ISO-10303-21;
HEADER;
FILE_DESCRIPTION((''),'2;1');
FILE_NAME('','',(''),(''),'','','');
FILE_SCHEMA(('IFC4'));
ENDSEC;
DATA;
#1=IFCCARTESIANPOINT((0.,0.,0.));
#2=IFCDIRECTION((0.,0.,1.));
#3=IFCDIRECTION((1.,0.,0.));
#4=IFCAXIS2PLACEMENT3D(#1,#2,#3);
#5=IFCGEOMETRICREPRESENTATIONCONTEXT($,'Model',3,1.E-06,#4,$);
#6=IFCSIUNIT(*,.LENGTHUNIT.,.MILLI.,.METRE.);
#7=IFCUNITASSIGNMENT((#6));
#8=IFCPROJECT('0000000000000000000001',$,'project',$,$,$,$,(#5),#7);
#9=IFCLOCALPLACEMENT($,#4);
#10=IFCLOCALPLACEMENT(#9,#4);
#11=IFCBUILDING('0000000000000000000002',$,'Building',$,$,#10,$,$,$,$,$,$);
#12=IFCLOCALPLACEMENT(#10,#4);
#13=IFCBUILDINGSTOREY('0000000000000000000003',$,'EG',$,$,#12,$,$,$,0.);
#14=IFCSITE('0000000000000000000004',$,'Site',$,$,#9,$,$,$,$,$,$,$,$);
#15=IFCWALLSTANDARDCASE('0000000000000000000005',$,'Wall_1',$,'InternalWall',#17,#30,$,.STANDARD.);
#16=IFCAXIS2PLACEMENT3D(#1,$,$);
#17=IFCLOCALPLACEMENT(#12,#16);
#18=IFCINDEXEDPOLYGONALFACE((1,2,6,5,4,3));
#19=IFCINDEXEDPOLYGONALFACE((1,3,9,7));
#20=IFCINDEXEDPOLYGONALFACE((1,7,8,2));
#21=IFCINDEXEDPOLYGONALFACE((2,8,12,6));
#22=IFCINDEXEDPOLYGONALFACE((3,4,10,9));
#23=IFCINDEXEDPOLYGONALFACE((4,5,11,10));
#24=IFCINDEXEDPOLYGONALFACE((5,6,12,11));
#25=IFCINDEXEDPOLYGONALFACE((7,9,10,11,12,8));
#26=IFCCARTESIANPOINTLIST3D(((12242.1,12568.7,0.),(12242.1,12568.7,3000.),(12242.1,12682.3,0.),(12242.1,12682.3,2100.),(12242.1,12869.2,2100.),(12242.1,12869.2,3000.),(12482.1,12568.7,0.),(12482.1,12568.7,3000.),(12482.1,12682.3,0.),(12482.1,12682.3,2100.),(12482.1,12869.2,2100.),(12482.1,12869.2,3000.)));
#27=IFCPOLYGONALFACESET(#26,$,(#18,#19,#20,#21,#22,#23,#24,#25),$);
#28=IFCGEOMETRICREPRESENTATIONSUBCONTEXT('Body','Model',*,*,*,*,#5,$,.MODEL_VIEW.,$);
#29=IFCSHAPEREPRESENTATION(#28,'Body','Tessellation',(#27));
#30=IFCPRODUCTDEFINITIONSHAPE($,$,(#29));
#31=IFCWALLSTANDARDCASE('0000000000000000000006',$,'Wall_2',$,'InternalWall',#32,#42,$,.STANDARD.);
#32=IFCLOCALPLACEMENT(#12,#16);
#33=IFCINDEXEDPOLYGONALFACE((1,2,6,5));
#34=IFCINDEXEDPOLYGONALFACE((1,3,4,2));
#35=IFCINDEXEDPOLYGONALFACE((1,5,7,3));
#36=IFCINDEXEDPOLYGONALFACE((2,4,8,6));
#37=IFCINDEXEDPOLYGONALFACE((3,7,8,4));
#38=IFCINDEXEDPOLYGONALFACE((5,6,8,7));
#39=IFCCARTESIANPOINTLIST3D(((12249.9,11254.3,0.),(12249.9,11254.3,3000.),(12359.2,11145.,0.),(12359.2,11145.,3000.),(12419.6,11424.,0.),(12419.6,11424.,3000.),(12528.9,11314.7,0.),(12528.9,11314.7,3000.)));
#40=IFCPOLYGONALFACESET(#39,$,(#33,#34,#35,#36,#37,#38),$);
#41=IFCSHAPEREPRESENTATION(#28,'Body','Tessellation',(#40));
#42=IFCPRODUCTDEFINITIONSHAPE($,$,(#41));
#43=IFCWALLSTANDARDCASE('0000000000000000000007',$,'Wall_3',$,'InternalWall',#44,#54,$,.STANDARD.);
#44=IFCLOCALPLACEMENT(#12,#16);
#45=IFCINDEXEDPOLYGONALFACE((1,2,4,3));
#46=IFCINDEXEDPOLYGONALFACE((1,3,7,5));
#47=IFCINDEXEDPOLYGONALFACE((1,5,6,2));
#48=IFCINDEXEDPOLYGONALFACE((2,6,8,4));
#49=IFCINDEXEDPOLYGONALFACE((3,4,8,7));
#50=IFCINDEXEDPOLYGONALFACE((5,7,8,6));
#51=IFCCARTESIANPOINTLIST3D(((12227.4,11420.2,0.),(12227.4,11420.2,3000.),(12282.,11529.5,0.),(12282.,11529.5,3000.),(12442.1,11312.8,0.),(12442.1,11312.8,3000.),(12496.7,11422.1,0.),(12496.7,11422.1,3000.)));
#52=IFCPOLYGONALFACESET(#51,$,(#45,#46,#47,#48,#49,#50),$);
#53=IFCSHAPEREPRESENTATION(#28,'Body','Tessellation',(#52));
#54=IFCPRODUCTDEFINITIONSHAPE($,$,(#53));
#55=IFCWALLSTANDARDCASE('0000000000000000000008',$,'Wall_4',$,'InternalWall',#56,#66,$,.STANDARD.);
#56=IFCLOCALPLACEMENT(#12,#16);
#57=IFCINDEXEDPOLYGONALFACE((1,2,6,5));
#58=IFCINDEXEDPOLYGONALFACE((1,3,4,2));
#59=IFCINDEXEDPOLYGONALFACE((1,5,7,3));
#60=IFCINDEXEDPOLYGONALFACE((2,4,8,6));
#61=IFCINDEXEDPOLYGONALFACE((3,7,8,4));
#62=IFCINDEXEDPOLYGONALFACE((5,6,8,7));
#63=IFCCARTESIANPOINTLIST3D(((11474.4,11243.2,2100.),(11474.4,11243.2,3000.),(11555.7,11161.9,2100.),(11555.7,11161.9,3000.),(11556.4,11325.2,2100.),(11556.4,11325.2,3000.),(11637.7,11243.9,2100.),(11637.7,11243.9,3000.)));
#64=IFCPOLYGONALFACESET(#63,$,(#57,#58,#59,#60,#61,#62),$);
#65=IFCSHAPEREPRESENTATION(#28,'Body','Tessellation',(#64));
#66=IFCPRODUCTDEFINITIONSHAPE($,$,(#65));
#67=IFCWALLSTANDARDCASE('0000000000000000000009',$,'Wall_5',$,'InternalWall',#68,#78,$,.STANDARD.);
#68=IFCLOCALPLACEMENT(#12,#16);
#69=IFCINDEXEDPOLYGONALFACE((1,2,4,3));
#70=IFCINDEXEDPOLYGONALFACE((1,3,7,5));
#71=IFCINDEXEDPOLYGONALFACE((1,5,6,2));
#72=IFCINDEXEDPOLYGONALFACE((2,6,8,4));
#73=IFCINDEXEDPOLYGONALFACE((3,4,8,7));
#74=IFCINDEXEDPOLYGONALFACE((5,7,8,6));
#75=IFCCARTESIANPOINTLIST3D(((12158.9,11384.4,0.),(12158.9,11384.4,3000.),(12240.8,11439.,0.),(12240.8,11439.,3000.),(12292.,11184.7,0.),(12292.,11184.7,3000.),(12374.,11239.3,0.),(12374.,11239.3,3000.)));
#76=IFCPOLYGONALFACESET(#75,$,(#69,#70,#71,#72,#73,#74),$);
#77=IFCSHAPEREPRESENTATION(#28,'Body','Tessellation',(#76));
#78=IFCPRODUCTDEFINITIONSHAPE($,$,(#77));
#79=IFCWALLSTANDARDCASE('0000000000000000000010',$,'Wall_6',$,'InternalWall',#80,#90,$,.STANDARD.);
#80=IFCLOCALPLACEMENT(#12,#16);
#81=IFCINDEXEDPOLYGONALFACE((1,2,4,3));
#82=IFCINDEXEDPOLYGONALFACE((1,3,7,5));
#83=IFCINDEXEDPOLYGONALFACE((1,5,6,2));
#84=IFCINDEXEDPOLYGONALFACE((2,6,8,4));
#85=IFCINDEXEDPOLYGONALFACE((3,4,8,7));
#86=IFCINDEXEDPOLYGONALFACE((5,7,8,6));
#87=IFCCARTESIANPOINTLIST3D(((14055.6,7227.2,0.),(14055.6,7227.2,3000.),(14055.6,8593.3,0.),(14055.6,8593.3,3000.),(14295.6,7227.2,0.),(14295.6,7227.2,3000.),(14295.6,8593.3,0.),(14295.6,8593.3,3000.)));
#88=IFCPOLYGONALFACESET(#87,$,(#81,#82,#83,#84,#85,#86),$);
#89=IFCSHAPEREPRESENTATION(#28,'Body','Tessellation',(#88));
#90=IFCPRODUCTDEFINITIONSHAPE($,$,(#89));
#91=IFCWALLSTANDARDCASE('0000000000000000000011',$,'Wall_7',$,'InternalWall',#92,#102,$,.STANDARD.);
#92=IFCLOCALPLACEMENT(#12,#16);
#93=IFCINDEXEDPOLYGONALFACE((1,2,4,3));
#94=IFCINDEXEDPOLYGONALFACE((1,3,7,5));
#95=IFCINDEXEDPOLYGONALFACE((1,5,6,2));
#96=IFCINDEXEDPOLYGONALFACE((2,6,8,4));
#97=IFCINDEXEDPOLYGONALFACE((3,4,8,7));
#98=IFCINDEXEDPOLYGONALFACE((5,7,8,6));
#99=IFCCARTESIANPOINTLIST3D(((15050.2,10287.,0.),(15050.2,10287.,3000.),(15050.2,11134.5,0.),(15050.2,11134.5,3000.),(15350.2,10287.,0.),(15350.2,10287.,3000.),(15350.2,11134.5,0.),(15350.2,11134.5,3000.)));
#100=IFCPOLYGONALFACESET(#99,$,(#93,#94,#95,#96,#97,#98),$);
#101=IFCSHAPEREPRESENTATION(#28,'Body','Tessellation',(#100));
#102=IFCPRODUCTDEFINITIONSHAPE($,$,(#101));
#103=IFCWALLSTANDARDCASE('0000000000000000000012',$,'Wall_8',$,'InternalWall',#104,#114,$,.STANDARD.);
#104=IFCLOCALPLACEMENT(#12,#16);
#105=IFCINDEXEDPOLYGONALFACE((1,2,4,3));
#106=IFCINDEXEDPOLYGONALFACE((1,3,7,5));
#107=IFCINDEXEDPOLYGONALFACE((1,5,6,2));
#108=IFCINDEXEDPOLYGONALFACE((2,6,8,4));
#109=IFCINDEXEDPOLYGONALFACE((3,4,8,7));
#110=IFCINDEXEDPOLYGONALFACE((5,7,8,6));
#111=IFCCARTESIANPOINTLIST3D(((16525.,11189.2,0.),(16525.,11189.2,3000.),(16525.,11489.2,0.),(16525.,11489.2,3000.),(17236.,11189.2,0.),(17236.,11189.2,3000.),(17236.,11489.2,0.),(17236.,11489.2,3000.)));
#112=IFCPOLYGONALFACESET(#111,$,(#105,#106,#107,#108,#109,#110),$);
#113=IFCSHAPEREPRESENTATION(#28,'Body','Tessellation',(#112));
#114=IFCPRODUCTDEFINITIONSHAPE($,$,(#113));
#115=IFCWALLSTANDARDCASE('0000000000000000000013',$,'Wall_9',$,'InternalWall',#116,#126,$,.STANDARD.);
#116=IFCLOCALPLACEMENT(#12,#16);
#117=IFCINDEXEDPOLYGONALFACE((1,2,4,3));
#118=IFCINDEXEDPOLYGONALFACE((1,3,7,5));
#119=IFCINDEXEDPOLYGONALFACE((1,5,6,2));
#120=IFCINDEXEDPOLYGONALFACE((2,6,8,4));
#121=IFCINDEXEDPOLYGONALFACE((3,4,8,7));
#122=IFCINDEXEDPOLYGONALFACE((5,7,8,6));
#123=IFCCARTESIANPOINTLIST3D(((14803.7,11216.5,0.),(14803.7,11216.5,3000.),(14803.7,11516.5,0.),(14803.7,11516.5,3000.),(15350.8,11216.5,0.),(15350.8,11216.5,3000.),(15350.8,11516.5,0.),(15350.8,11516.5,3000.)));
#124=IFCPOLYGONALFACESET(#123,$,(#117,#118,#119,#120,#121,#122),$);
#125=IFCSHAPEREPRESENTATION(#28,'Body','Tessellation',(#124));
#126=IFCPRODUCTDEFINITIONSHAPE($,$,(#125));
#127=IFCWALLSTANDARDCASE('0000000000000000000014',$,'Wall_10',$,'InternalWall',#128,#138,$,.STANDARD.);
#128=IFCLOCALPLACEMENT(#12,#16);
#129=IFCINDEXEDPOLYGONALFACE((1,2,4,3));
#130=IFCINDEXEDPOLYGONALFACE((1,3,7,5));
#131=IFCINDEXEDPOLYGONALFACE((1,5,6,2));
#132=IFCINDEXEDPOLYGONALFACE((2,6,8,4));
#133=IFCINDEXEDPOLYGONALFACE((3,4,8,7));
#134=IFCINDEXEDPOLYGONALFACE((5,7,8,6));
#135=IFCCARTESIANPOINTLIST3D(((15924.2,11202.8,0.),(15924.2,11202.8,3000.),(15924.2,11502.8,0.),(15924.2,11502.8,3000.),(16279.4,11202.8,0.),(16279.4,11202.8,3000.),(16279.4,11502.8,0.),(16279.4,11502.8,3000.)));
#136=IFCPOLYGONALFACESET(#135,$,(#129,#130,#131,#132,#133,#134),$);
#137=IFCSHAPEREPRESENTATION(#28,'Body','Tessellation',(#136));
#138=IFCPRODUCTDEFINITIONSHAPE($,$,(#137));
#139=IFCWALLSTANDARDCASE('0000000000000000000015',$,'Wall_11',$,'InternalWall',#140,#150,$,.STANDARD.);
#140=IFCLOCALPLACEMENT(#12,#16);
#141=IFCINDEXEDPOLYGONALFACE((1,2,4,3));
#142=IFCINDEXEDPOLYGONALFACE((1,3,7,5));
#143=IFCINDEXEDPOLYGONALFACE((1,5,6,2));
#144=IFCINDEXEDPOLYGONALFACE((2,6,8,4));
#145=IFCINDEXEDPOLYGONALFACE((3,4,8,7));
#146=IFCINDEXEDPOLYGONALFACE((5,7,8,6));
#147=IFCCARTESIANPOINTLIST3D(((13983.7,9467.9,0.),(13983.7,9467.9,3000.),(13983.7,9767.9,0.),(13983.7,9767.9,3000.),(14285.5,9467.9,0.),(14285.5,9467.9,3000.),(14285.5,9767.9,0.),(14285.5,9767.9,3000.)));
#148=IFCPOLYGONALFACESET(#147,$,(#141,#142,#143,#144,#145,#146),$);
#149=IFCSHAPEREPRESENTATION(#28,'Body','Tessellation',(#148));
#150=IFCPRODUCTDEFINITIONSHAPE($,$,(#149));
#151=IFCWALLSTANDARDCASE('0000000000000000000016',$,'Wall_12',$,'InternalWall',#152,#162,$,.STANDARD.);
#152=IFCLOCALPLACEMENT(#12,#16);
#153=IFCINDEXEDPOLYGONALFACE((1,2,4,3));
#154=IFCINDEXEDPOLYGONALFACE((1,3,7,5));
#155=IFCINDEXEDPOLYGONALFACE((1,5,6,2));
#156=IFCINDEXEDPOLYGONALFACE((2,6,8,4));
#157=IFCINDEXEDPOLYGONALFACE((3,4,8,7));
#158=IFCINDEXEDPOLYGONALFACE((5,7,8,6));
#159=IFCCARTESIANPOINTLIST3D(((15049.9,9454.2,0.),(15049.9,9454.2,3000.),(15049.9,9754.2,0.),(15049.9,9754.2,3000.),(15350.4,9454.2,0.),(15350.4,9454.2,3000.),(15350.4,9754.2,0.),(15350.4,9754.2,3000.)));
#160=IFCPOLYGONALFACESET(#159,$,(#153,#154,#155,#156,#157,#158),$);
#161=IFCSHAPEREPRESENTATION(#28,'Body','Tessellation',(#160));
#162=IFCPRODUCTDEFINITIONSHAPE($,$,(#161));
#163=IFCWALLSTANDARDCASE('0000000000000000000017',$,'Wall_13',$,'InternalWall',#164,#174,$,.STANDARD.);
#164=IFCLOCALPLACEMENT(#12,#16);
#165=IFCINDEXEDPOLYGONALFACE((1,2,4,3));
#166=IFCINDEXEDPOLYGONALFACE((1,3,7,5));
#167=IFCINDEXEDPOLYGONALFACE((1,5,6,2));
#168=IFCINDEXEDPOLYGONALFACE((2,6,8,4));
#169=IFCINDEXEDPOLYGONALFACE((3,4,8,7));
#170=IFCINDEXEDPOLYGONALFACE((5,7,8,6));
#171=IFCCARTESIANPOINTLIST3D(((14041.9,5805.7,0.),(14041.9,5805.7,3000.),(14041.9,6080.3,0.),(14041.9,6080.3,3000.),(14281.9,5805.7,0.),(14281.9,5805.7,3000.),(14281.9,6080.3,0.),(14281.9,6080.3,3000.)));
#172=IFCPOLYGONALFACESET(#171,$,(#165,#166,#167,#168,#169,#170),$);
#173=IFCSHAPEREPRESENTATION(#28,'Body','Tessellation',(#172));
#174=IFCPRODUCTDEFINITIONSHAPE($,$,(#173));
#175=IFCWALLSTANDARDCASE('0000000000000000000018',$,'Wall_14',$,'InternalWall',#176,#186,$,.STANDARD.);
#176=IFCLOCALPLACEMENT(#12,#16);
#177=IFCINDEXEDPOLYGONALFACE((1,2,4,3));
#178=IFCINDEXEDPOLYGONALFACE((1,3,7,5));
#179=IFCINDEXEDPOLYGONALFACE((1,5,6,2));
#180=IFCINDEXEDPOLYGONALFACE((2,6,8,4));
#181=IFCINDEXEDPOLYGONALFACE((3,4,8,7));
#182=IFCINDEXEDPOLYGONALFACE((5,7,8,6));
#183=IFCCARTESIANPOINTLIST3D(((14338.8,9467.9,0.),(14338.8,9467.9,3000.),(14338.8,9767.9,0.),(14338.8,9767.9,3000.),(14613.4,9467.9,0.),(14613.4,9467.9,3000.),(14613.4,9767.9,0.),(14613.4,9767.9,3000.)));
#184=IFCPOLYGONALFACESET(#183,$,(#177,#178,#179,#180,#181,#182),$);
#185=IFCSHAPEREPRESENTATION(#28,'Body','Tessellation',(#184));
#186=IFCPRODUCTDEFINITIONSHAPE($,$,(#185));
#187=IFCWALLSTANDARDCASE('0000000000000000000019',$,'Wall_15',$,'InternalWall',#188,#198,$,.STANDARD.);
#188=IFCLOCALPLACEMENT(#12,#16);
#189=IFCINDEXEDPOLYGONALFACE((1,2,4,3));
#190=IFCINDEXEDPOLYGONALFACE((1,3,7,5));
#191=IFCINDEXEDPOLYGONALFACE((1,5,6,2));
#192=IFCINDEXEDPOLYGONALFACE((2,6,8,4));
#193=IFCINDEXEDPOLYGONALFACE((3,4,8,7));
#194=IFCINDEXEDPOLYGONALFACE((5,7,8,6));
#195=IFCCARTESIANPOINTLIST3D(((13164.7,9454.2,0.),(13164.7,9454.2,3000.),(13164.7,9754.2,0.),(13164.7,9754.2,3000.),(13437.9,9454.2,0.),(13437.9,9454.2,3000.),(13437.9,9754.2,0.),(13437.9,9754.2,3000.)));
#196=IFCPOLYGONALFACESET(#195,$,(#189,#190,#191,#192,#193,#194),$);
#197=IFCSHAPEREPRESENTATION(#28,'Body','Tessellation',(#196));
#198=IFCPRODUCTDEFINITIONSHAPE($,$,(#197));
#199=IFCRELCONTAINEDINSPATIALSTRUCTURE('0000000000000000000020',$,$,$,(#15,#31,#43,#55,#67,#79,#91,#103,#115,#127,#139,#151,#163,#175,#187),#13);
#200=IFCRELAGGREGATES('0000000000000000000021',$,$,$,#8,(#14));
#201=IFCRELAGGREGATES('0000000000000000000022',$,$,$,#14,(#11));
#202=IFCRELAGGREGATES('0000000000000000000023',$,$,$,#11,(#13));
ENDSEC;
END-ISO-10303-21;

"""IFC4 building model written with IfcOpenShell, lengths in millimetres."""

from ifc_helpers import new_model, si_unit, frame, origin_with_axes, place, context, subcontext, project, spatial, rectangle, extrude, element, save


model = new_model("IFC4")

# Units and contexts
model_context = context("Model", 3, precision=1e-06, world=origin_with_axes())
body_context = subcontext(model_context, "Body", "Model", "MODEL_VIEW")
ifc_project = project(units=[si_unit("LENGTHUNIT", "METRE", prefix="MILLI")], contexts=[model_context])

# Site, building, storey
site_placement = place(None, origin_with_axes())
site = spatial("IfcSite", under=ifc_project, at=site_placement, Name="Site")
building_placement = place(site_placement, origin_with_axes())
building = spatial("IfcBuilding", under=site, at=building_placement, Name="Building")
storey_placement = place(building_placement, origin_with_axes())
storey = spatial("IfcBuildingStorey", under=building, at=storey_placement, Name="EG", Elevation=0.0)

# Wall, opening
wall_1_placement = place(storey_placement, origin_with_axes())
wall_1 = element("IfcWallStandardCase", 1, at=wall_1_placement, inside=storey, Name="Wall_1", ObjectType="InternalWall", PredefinedType="STANDARD", context=body_context, shape_type="SweptSolid", body=[
    extrude(rectangle(XDim=300.5, YDim=240.0), frame((12362.1, 12719.0, 0.0), z_axis=(0.0, 0.0, 1.0), x_axis=(0.0, -1.0, 0.0)), (0.0, 0.0, 1.0), 3000.0),
])
opening_1_placement = place(wall_1_placement, origin_with_axes())
element("IfcOpeningElement", 2, at=opening_1_placement, inside=storey, cuts=wall_1, context=body_context, shape_type="SweptSolid", body=[
    extrude(rectangle(XDim=937.5, YDim=240.0), frame((12362.1, 13151.0, 0.0), z_axis=(0.0, 0.0, 1.0), x_axis=(0.0, -1.0, 0.0)), (0.0, 0.0, 1.0), 2100.0),
])

# Walls
wall_2_placement = place(storey_placement, origin_with_axes())
element("IfcWallStandardCase", 3, at=wall_2_placement, inside=storey, Name="Wall_2", ObjectType="InternalWall", PredefinedType="STANDARD", context=body_context, shape_type="SweptSolid", body=[
    extrude(rectangle(XDim=154.6, YDim=240.0), frame((12389.4, 11284.5, 0.0), z_axis=(0.0, 0.0, 1.0), x_axis=(0.707107, -0.707107, 0.0)), (0.0, 0.0, 1.0), 3000.0),
])
wall_3_placement = place(storey_placement, origin_with_axes())
element("IfcWallStandardCase", 4, at=wall_3_placement, inside=storey, Name="Wall_3", ObjectType="InternalWall", PredefinedType="STANDARD", context=body_context, shape_type="SweptSolid", body=[
    extrude(rectangle(XDim=122.2, YDim=240.0), frame((12362.1, 11421.1, 0.0), z_axis=(0.0, 0.0, 1.0), x_axis=(-0.447214, -0.894427, 0.0)), (0.0, 0.0, 1.0), 3000.0),
])

# Wall, opening
wall_4_placement = place(storey_placement, origin_with_axes())
wall_4 = element("IfcWallStandardCase", 5, at=wall_4_placement, inside=storey, Name="Wall_4", ObjectType="InternalWall", PredefinedType="STANDARD", context=body_context, shape_type="SweptSolid", body=[
    extrude(rectangle(XDim=115.9, YDim=115.0), frame((11556.0, 11243.5, 0.0), z_axis=(0.0, 0.0, 1.0), x_axis=(-0.707107, -0.707107, 0.0)), (0.0, 0.0, 1.0), 3000.0),
])
opening_2_placement = place(wall_4_placement, origin_with_axes())
element("IfcOpeningElement", 6, at=opening_2_placement, inside=storey, cuts=wall_4, context=body_context, shape_type="SweptSolid", body=[
    extrude(rectangle(XDim=939.1, YDim=115.0), frame((11399.7, 11087.2, 0.0), z_axis=(0.0, 0.0, 1.0), x_axis=(-0.707107, -0.707107, 0.0)), (0.0, 0.0, 1.0), 2100.0),
])

# Walls
wall_5_placement = place(storey_placement, origin_with_axes())
element("IfcWallStandardCase", 7, at=wall_5_placement, inside=storey, Name="Wall_5", ObjectType="InternalWall", PredefinedType="STANDARD", context=body_context, shape_type="SweptSolid", body=[
    extrude(rectangle(XDim=98.5, YDim=240.0), frame((12266.4, 11311.9, 0.0), z_axis=(0.0, 0.0, 1.0), x_axis=(-0.83205, -0.5547, 0.0)), (0.0, 0.0, 1.0), 3000.0),
])
wall_6_placement = place(storey_placement, origin_with_axes())
element("IfcWallStandardCase", 8, at=wall_6_placement, inside=storey, Name="Wall_6", ObjectType="InternalWall", PredefinedType="STANDARD", context=body_context, shape_type="SweptSolid", body=[
    extrude(rectangle(XDim=1366.1, YDim=240.0), frame((14175.6, 7910.2, 0.0), z_axis=(0.0, 0.0, 1.0), x_axis=(0.0, -1.0, 0.0)), (0.0, 0.0, 1.0), 3000.0),
])
wall_7_placement = place(storey_placement, origin_with_axes())
element("IfcWallStandardCase", 9, at=wall_7_placement, inside=storey, Name="Wall_7", ObjectType="InternalWall", PredefinedType="STANDARD", context=body_context, shape_type="SweptSolid", body=[
    extrude(rectangle(XDim=847.4, YDim=300.0), frame((15200.2, 10710.8, 0.0), z_axis=(0.0, 0.0, 1.0), x_axis=(0.0, 1.0, 0.0)), (0.0, 0.0, 1.0), 3000.0),
])
wall_8_placement = place(storey_placement, origin_with_axes())
element("IfcWallStandardCase", 10, at=wall_8_placement, inside=storey, Name="Wall_8", ObjectType="InternalWall", PredefinedType="STANDARD", context=body_context, shape_type="SweptSolid", body=[
    extrude(rectangle(XDim=710.9, YDim=300.0), frame((16880.5, 11339.2, 0.0), z_axis=(0.0, 0.0, 1.0), x_axis=(1.0, 0.0, 0.0)), (0.0, 0.0, 1.0), 3000.0),
])
wall_9_placement = place(storey_placement, origin_with_axes())
element("IfcWallStandardCase", 11, at=wall_9_placement, inside=storey, Name="Wall_9", ObjectType="InternalWall", PredefinedType="STANDARD", context=body_context, shape_type="SweptSolid", body=[
    extrude(rectangle(XDim=547.1, YDim=300.0), frame((15077.2, 11366.5, 0.0), z_axis=(0.0, 0.0, 1.0), x_axis=(1.0, 0.0, 0.0)), (0.0, 0.0, 1.0), 3000.0),
])
wall_10_placement = place(storey_placement, origin_with_axes())
element("IfcWallStandardCase", 12, at=wall_10_placement, inside=storey, Name="Wall_10", ObjectType="InternalWall", PredefinedType="STANDARD", context=body_context, shape_type="SweptSolid", body=[
    extrude(rectangle(XDim=355.2, YDim=300.0), frame((16101.8, 11352.8, 0.0), z_axis=(0.0, 0.0, 1.0), x_axis=(-1.0, 0.0, 0.0)), (0.0, 0.0, 1.0), 3000.0),
])
wall_11_placement = place(storey_placement, origin_with_axes())
element("IfcWallStandardCase", 13, at=wall_11_placement, inside=storey, Name="Wall_11", ObjectType="InternalWall", PredefinedType="STANDARD", context=body_context, shape_type="SweptSolid", body=[
    extrude(rectangle(XDim=301.8, YDim=300.0), frame((14134.6, 9617.9, 0.0), z_axis=(0.0, 0.0, 1.0), x_axis=(1.0, 0.0, 0.0)), (0.0, 0.0, 1.0), 3000.0),
])
wall_12_placement = place(storey_placement, origin_with_axes())
element("IfcWallStandardCase", 14, at=wall_12_placement, inside=storey, Name="Wall_12", ObjectType="InternalWall", PredefinedType="STANDARD", context=body_context, shape_type="SweptSolid", body=[
    extrude(rectangle(XDim=300.5, YDim=300.0), frame((15200.2, 9604.2, 0.0), z_axis=(0.0, 0.0, 1.0), x_axis=(1.0, 0.0, 0.0)), (0.0, 0.0, 1.0), 3000.0),
])
wall_13_placement = place(storey_placement, origin_with_axes())
element("IfcWallStandardCase", 15, at=wall_13_placement, inside=storey, Name="Wall_13", ObjectType="InternalWall", PredefinedType="STANDARD", context=body_context, shape_type="SweptSolid", body=[
    extrude(rectangle(XDim=274.6, YDim=240.0), frame((14161.9, 5943.0, 0.0), z_axis=(0.0, 0.0, 1.0), x_axis=(0.0, -1.0, 0.0)), (0.0, 0.0, 1.0), 3000.0),
])
wall_14_placement = place(storey_placement, origin_with_axes())
element("IfcWallStandardCase", 16, at=wall_14_placement, inside=storey, Name="Wall_14", ObjectType="InternalWall", PredefinedType="STANDARD", context=body_context, shape_type="SweptSolid", body=[
    extrude(rectangle(XDim=274.6, YDim=300.0), frame((14476.1, 9617.9, 0.0), z_axis=(0.0, 0.0, 1.0), x_axis=(1.0, 0.0, 0.0)), (0.0, 0.0, 1.0), 3000.0),
])
wall_15_placement = place(storey_placement, origin_with_axes())
element("IfcWallStandardCase", 17, at=wall_15_placement, inside=storey, Name="Wall_15", ObjectType="InternalWall", PredefinedType="STANDARD", context=body_context, shape_type="SweptSolid", body=[
    extrude(rectangle(XDim=273.2, YDim=300.0), frame((13301.3, 9604.2, 0.0), z_axis=(0.0, 0.0, 1.0), x_axis=(-1.0, 0.0, 0.0)), (0.0, 0.0, 1.0), 3000.0),
])

save(model, "model.ifc")
